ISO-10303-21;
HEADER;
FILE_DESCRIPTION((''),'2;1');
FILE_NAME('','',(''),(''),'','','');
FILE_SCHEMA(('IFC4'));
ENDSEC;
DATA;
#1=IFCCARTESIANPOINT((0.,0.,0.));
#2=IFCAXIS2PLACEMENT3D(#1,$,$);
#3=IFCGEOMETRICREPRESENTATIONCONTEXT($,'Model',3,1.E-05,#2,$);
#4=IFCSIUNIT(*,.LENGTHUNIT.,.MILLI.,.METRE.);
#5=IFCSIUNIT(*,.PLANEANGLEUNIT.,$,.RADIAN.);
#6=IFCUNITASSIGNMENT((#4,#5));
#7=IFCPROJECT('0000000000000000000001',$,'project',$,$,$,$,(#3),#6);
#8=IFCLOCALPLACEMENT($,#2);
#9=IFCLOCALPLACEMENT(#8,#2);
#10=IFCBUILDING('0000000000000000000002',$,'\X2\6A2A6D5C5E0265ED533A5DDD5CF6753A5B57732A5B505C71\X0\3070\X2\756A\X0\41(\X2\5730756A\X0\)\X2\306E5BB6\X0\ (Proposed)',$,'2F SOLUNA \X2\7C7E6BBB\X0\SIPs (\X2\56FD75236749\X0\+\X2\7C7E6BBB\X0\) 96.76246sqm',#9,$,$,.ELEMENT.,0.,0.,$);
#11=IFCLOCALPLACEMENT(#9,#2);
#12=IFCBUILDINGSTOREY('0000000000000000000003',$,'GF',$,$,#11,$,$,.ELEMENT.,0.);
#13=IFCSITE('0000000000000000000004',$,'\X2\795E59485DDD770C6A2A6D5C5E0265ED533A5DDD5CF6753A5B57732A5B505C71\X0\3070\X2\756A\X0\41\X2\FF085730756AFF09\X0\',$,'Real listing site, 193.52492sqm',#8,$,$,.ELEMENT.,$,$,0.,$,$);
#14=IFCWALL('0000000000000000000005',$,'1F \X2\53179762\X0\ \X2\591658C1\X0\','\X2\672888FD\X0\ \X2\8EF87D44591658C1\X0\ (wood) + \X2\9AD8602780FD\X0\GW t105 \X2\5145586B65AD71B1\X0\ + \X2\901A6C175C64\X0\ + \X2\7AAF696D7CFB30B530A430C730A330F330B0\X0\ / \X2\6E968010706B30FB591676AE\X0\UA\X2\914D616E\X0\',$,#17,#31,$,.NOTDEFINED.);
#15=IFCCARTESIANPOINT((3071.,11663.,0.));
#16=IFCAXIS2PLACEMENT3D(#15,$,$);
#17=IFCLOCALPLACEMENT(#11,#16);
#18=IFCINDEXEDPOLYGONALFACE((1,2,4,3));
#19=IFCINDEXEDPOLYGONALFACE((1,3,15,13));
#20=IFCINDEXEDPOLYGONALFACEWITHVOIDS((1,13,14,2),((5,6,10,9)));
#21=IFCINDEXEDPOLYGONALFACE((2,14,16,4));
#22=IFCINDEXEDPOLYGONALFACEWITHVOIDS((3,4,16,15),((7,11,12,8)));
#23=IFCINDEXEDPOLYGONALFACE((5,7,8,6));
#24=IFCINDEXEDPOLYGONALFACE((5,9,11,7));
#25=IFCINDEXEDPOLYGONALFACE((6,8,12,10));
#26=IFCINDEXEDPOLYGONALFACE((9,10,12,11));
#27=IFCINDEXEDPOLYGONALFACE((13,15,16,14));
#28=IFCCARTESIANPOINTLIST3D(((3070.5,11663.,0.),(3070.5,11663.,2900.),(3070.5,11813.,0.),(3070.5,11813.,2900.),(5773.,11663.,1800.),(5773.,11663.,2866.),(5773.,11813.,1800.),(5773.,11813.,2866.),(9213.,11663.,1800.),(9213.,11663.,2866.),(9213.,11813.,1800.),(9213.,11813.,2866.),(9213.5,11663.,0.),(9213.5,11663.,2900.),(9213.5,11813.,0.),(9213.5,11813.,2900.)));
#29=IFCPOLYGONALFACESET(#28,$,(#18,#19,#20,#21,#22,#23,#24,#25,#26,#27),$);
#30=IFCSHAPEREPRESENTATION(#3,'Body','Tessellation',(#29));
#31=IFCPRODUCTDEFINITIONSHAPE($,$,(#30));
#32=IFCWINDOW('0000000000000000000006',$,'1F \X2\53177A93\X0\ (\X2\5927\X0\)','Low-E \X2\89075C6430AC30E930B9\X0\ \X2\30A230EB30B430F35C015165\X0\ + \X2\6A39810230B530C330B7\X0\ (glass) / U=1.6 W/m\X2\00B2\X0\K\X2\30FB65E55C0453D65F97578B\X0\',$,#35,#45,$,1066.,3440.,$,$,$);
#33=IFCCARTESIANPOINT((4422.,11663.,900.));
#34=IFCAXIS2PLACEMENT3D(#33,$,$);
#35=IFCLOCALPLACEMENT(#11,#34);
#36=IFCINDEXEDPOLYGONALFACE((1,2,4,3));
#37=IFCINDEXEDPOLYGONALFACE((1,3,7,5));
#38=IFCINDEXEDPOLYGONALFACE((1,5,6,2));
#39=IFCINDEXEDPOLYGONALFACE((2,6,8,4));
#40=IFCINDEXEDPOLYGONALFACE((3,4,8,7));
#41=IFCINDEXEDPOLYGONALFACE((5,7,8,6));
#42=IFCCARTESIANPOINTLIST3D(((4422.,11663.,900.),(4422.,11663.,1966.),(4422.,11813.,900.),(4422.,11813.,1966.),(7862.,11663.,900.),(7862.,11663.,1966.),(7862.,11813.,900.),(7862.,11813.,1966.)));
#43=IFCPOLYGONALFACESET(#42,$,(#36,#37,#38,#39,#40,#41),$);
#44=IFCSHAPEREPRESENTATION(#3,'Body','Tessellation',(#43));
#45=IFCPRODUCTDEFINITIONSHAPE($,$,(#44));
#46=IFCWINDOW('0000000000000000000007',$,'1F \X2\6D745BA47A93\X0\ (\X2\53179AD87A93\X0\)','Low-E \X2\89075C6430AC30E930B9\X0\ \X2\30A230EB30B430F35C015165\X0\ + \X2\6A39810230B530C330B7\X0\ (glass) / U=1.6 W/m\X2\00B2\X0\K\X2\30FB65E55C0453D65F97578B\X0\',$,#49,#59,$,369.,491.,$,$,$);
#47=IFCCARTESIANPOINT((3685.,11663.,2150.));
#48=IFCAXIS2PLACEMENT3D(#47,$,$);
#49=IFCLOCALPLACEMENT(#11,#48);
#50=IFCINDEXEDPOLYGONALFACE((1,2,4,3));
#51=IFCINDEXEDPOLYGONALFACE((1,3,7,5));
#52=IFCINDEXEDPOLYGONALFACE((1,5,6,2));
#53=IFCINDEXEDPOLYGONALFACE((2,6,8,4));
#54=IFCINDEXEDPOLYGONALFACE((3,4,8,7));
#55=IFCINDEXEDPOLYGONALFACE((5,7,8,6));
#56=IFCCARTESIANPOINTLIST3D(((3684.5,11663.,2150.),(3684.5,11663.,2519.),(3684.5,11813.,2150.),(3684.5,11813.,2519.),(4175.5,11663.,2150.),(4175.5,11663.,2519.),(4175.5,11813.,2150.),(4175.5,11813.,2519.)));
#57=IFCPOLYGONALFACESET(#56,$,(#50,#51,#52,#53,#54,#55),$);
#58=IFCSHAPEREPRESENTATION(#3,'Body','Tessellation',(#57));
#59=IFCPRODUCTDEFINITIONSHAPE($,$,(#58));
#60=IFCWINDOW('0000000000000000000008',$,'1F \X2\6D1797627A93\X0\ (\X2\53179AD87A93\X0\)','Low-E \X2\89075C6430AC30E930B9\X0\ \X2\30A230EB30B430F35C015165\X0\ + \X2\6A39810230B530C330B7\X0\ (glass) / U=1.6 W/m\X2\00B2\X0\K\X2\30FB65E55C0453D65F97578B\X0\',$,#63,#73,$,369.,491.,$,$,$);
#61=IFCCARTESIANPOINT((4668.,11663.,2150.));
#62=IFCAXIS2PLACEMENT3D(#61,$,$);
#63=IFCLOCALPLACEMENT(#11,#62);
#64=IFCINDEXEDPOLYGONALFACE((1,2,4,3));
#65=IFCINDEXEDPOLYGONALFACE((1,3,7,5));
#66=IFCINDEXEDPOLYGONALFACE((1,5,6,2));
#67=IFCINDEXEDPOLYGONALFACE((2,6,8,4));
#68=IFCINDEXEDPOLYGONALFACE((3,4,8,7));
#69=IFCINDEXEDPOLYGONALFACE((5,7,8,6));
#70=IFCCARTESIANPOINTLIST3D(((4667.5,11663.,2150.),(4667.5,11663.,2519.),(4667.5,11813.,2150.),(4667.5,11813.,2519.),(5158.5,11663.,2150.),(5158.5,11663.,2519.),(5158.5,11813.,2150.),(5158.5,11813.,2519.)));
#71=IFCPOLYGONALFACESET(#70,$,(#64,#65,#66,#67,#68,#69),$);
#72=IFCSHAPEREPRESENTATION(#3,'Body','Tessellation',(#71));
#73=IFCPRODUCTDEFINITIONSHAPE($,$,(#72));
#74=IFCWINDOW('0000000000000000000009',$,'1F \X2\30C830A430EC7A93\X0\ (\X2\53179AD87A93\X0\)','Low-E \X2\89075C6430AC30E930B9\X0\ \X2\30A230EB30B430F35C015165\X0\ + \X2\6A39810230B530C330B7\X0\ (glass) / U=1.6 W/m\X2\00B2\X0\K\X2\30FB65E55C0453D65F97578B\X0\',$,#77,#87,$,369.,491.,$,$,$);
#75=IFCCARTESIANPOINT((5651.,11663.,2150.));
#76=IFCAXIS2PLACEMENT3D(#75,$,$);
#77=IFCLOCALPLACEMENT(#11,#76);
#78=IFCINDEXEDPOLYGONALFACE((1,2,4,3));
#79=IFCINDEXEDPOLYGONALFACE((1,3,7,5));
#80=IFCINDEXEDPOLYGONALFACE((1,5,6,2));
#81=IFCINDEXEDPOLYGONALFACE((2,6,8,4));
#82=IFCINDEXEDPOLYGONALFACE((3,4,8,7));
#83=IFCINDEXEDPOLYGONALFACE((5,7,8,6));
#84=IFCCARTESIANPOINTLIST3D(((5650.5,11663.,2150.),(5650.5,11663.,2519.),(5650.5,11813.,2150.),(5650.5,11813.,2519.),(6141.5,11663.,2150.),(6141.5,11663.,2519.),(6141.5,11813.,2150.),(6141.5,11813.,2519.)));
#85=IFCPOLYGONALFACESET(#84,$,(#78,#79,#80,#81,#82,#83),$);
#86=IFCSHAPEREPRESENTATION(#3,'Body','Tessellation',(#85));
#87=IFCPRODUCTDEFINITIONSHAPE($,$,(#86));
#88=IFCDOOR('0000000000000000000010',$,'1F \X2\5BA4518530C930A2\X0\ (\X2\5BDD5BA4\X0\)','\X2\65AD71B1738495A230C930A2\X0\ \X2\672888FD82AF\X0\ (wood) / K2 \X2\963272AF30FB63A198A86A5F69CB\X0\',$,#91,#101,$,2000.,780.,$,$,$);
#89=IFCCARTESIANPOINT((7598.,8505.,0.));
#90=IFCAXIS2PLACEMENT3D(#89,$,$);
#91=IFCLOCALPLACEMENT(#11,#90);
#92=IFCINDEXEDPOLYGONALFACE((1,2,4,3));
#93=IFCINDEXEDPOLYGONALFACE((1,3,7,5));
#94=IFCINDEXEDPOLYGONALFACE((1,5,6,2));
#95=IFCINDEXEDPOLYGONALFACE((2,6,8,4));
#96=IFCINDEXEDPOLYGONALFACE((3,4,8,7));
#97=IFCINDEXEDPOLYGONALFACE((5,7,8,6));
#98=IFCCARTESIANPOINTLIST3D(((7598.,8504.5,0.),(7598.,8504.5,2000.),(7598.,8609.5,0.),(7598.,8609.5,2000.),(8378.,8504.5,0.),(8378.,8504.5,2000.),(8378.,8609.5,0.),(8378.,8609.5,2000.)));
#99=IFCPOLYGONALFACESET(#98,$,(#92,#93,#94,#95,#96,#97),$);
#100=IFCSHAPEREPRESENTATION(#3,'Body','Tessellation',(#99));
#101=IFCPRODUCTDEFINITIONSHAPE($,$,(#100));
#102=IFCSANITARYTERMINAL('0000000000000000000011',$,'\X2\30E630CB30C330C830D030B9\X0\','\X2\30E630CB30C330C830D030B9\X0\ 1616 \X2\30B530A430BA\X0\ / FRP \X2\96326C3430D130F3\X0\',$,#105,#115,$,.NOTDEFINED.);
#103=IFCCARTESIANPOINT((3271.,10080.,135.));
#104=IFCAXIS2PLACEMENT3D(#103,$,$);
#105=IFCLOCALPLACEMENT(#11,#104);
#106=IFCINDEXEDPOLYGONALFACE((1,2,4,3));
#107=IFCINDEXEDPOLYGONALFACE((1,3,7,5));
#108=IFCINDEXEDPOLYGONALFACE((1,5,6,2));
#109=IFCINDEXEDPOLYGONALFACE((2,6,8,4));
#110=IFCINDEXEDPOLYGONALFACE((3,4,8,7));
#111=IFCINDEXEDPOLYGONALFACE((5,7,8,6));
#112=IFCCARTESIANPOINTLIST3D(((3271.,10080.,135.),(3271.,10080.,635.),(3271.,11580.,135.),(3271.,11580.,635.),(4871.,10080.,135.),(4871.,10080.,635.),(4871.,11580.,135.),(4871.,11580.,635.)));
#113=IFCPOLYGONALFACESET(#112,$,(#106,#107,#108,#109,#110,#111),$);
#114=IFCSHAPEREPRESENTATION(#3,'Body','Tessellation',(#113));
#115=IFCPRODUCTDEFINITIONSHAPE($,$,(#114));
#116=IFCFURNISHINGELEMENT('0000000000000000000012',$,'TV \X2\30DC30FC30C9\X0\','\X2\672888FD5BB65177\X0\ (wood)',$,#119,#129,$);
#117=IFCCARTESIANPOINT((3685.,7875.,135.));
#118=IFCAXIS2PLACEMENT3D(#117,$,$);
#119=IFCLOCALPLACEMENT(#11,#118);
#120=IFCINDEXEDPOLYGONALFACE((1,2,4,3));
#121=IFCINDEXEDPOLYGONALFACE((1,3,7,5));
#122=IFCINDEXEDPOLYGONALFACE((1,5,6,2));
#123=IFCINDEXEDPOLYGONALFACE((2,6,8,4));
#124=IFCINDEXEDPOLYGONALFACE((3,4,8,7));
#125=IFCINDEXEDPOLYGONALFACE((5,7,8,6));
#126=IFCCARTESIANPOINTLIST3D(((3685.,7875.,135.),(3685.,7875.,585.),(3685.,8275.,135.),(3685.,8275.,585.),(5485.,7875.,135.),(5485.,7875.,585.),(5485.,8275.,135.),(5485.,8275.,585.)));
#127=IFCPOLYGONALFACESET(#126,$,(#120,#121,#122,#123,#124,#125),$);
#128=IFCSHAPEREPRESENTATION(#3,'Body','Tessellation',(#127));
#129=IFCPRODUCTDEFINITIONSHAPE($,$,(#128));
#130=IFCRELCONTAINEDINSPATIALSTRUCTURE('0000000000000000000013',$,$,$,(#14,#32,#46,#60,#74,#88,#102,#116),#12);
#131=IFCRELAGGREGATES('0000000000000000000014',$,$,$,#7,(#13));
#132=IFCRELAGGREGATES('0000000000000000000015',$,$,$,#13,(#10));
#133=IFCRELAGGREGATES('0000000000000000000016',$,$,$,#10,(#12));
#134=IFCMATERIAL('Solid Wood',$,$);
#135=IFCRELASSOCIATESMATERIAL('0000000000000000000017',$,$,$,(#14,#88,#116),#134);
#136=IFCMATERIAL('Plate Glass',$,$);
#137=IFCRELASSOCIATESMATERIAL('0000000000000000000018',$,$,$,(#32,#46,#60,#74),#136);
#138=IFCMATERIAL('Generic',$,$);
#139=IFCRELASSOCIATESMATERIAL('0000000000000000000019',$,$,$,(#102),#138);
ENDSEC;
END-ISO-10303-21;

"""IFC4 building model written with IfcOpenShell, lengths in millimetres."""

from ifc_helpers import new_model, si_unit, frame, frame_2d, origin, place, context, project, spatial, rectangle, extrude, material, element, fill, save


model = new_model("IFC4")

# Units and contexts
model_context = context("Model", 3, precision=1e-05, world=origin())
ifc_project = project(units=[si_unit("LENGTHUNIT", "METRE", prefix="MILLI"), si_unit("PLANEANGLEUNIT", "RADIAN")], contexts=[model_context])

# Site, building, storey
site_placement = place(None, origin())
site = spatial("IfcSite", under=ifc_project, at=site_placement, Name="神奈川県横浜市旭区川島町字猪子山3070番41（地番）", ObjectType="Real listing site, 193.52492sqm", CompositionType="ELEMENT", RefElevation=0.0)
building_placement = place(site_placement, origin())
building = spatial("IfcBuilding", under=site, at=building_placement, Name="横浜市旭区川島町字猪子山3070番41(地番)の家 (Proposed)", ObjectType="2F SOLUNA 籾殻SIPs (国産杉+籾殻) 96.76246sqm", CompositionType="ELEMENT", ElevationOfRefHeight=0.0, ElevationOfTerrain=0.0)
storey_placement = place(building_placement, origin())
storey = spatial("IfcBuildingStorey", under=building, at=storey_placement, Name="GF", CompositionType="ELEMENT", Elevation=0.0)

# Wall, openings, windows
ifc_material_1 = material(Name="Solid Wood")
wall_1_placement = place(storey_placement, frame((3071.0, 11663.0, 0.0)))
wall_1 = element("IfcWall", 1, at=wall_1_placement, inside=storey, material=ifc_material_1, Name="1F 北面 外壁", Description="木製 軸組外壁 (wood) + 高性能GW t105 充填断熱 + 通気層 + 窯業系サイディング / 準耐火・外皮UA配慮", PredefinedType="NOTDEFINED", context=model_context, shape_type="SweptSolid", body=[
    extrude(rectangle(XDim=6143.0, YDim=150.0, at=frame_2d((3071.0, 75.0))), frame((3071.0, 11663.0, 0.0)), (0.0, 0.0, 1.0), 2900.0),
])
opening_1_placement = place(storey_placement, frame((4422.0, 11663.0, 900.0)))
opening_1 = element("IfcOpeningElement", 2, at=opening_1_placement, cuts=wall_1, PredefinedType="NOTDEFINED", context=model_context, shape_type="SweptSolid", body=[
    extrude(rectangle(XDim=3440.0, YDim=150.0, at=frame_2d((1720.0, 75.0))), frame((4422.0, 11663.0, 900.0)), (0.0, 0.0, 1.0), 1066.0),
])
opening_2_placement = place(storey_placement, frame((3685.0, 11663.0, 2150.0)))
opening_2 = element("IfcOpeningElement", 3, at=opening_2_placement, cuts=wall_1, PredefinedType="NOTDEFINED", context=model_context, shape_type="SweptSolid", body=[
    extrude(rectangle(XDim=491.0, YDim=150.0, at=frame_2d((245.0, 75.0))), frame((3685.0, 11663.0, 2150.0)), (0.0, 0.0, 1.0), 369.0),
])
opening_3_placement = place(storey_placement, frame((4668.0, 11663.0, 2150.0)))
opening_3 = element("IfcOpeningElement", 4, at=opening_3_placement, cuts=wall_1, PredefinedType="NOTDEFINED", context=model_context, shape_type="SweptSolid", body=[
    extrude(rectangle(XDim=491.0, YDim=150.0, at=frame_2d((245.0, 75.0))), frame((4668.0, 11663.0, 2150.0)), (0.0, 0.0, 1.0), 369.0),
])
opening_4_placement = place(storey_placement, frame((5651.0, 11663.0, 2150.0)))
opening_4 = element("IfcOpeningElement", 5, at=opening_4_placement, cuts=wall_1, PredefinedType="NOTDEFINED", context=model_context, shape_type="SweptSolid", body=[
    extrude(rectangle(XDim=491.0, YDim=150.0, at=frame_2d((245.0, 75.0))), frame((5651.0, 11663.0, 2150.0)), (0.0, 0.0, 1.0), 369.0),
])
ifc_material_2 = material(Name="Plate Glass")
window_1_placement = place(storey_placement, frame((4422.0, 11663.0, 900.0)))
window_1 = element("IfcWindow", 6, at=window_1_placement, inside=storey, material=ifc_material_2, Name="1F 北窓 (大)", Description="Low-E 複層ガラス アルゴン封入 + 樹脂サッシ (glass) / U=1.6 W/m²K・日射取得型", OverallHeight=1066.0, OverallWidth=3440.0, context=model_context, shape_type="SweptSolid", body=[
    extrude(rectangle(XDim=3440.0, YDim=150.0, at=frame_2d((1720.0, 75.0))), frame((4422.0, 11663.0, 900.0)), (0.0, 0.0, 1.0), 1066.0),
])
fill(opening_1, window_1)
window_2_placement = place(storey_placement, frame((3685.0, 11663.0, 2150.0)))
window_2 = element("IfcWindow", 7, at=window_2_placement, inside=storey, material=ifc_material_2, Name="1F 浴室窓 (北高窓)", Description="Low-E 複層ガラス アルゴン封入 + 樹脂サッシ (glass) / U=1.6 W/m²K・日射取得型", OverallHeight=369.0, OverallWidth=491.0, context=model_context, shape_type="SweptSolid", body=[
    extrude(rectangle(XDim=491.0, YDim=150.0, at=frame_2d((245.0, 75.0))), frame((3685.0, 11663.0, 2150.0)), (0.0, 0.0, 1.0), 369.0),
])
fill(opening_2, window_2)
window_3_placement = place(storey_placement, frame((4668.0, 11663.0, 2150.0)))
window_3 = element("IfcWindow", 8, at=window_3_placement, inside=storey, material=ifc_material_2, Name="1F 洗面窓 (北高窓)", Description="Low-E 複層ガラス アルゴン封入 + 樹脂サッシ (glass) / U=1.6 W/m²K・日射取得型", OverallHeight=369.0, OverallWidth=491.0, context=model_context, shape_type="SweptSolid", body=[
    extrude(rectangle(XDim=491.0, YDim=150.0, at=frame_2d((245.0, 75.0))), frame((4668.0, 11663.0, 2150.0)), (0.0, 0.0, 1.0), 369.0),
])
fill(opening_3, window_3)
window_4_placement = place(storey_placement, frame((5651.0, 11663.0, 2150.0)))
window_4 = element("IfcWindow", 9, at=window_4_placement, inside=storey, material=ifc_material_2, Name="1F トイレ窓 (北高窓)", Description="Low-E 複層ガラス アルゴン封入 + 樹脂サッシ (glass) / U=1.6 W/m²K・日射取得型", OverallHeight=369.0, OverallWidth=491.0, context=model_context, shape_type="SweptSolid", body=[
    extrude(rectangle(XDim=491.0, YDim=150.0, at=frame_2d((245.0, 75.0))), frame((5651.0, 11663.0, 2150.0)), (0.0, 0.0, 1.0), 369.0),
])
fill(opening_4, window_4)

# Door
door_1_placement = place(storey_placement, frame((7598.0, 8505.0, 0.0)))
element("IfcDoor", 10, at=door_1_placement, inside=storey, material=ifc_material_1, Name="1F 室内ドア (寝室)", Description="断熱玄関ドア 木製芯 (wood) / K2 防犯・採風機構", OverallHeight=2000.0, OverallWidth=780.0, context=model_context, shape_type="SweptSolid", body=[
    extrude(rectangle(XDim=780.0, YDim=105.0, at=frame_2d((390.0, 52.0))), frame((7598.0, 8505.0, 0.0)), (0.0, 0.0, 1.0), 2000.0),
])

# Sanitary terminal
ifc_material_3 = material(Name="Generic")
sanitary_terminal_placement = place(storey_placement, frame((3271.0, 10080.0, 135.0)))
element("IfcSanitaryTerminal", 11, at=sanitary_terminal_placement, inside=storey, material=ifc_material_3, Name="ユニットバス", Description="ユニットバス 1616 サイズ / FRP 防水パン", PredefinedType="NOTDEFINED", context=model_context, shape_type="SweptSolid", body=[
    extrude(rectangle(XDim=1600.0, YDim=1500.0, at=frame_2d((800.0, 750.0))), frame((3271.0, 10080.0, 135.0)), (0.0, 0.0, 1.0), 500.0),
])

# Furnishing element
furnishing_placement = place(storey_placement, frame((3685.0, 7875.0, 135.0)))
element("IfcFurnishingElement", 12, at=furnishing_placement, inside=storey, material=ifc_material_1, Name="TV ボード", Description="木製家具 (wood)", context=model_context, shape_type="SweptSolid", body=[
    extrude(rectangle(XDim=1800.0, YDim=400.0, at=frame_2d((900.0, 200.0))), frame((3685.0, 7875.0, 135.0)), (0.0, 0.0, 1.0), 450.0),
])

save(model, "model.ifc")
